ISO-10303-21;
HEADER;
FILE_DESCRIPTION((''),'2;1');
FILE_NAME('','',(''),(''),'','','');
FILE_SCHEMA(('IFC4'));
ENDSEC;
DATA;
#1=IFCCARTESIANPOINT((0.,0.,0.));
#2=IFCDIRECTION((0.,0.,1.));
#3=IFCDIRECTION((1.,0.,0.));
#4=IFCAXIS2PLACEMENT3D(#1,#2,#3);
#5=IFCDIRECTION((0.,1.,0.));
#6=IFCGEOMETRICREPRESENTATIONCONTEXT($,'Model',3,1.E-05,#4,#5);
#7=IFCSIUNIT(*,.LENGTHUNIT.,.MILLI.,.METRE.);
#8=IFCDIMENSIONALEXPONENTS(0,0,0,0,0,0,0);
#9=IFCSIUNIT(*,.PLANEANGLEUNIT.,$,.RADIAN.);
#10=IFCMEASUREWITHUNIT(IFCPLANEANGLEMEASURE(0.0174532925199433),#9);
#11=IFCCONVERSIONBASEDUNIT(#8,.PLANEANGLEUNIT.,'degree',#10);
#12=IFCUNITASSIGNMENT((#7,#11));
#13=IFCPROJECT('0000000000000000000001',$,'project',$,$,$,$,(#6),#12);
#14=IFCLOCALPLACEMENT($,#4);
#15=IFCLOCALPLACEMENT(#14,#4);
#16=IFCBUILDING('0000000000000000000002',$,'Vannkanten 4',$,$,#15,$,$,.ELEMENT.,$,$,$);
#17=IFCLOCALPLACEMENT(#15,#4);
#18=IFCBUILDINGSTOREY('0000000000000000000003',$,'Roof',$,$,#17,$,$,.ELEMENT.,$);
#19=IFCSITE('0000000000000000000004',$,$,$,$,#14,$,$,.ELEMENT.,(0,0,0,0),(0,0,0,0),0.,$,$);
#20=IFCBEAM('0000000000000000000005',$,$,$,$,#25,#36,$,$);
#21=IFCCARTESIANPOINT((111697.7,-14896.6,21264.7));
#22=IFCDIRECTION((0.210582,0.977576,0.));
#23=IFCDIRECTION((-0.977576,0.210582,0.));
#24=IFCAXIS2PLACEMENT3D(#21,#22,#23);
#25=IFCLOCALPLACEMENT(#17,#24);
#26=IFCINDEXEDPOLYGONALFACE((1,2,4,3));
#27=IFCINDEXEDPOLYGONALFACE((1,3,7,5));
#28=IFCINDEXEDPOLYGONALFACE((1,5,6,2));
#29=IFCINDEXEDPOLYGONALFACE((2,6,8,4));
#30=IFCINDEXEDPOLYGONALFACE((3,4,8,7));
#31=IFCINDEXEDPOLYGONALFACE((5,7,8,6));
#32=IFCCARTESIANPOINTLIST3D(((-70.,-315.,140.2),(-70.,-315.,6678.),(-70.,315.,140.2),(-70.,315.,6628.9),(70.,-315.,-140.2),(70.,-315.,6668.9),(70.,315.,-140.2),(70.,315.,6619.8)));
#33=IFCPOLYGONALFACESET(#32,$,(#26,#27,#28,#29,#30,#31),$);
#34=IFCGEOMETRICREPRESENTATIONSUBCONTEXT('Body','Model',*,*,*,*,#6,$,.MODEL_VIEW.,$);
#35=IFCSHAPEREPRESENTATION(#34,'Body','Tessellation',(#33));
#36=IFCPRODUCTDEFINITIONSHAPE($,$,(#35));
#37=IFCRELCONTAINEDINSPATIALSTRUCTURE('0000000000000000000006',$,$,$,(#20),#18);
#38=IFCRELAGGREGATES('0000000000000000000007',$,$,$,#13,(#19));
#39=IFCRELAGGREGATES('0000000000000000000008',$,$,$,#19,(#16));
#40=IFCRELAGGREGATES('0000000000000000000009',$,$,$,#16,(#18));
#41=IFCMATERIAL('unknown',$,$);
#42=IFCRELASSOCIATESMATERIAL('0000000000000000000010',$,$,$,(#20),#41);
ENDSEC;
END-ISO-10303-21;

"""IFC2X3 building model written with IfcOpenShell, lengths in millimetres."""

from ifc_helpers import new_model, entity, si_unit, converted_unit, direction, frame, origin_with_axes, place, context, subcontext, project, spatial, polyline, segment, composite_curve, outline, extrude, clip, halfspace, material, element, save


model = new_model("IFC2X3")

# Units and contexts
model_context = context("Model", 3, precision=1e-05, world=origin_with_axes(), true_north=direction((0.0, 1.0, 0.0)))
body_context = subcontext(model_context, "Body", "Model", "MODEL_VIEW")
ifc_project = project(units=[si_unit("LENGTHUNIT", "METRE", prefix="MILLI"), converted_unit("PLANEANGLEUNIT", "degree", entity("IfcPlaneAngleMeasure", 0.0174532925199433), si_unit("PLANEANGLEUNIT", "RADIAN"), dimensions=[0, 0, 0, 0, 0, 0, 0])], contexts=[model_context])

# Site, building, storey
site_placement = place(None, origin_with_axes())
site = spatial("IfcSite", under=ifc_project, at=site_placement, CompositionType="ELEMENT", RefLatitude=(0, 0, 0, 0), RefLongitude=(0, 0, 0, 0), RefElevation=0.0)
building_placement = place(site_placement, origin_with_axes())
building = spatial("IfcBuilding", under=site, at=building_placement, Name="Vannkanten 4", CompositionType="ELEMENT")
storey_placement = place(building_placement, origin_with_axes())
storey = spatial("IfcBuildingStorey", under=building, at=storey_placement, Name="Roof", CompositionType="ELEMENT")

# Shared definitions
ifc_material = material(Name="unknown")

# Beam
beam_1_placement = place(storey_placement, frame((111697.7, -14896.6, 21264.7), z_axis=(0.210582, 0.977576, 0.0), x_axis=(-0.977576, 0.210582, 0.0)))
element("IfcBeam", 1, at=beam_1_placement, inside=storey, material=ifc_material, context=body_context, shape_type="Clipping", body=[
    clip(clip(extrude(outline(composite_curve([segment(polyline([(-70.0, 315.0), (-70.0, -315.0), (70.0, -315.0), (70.0, 315.0), (-70.0, 315.0)]), True, "CONTINUOUS")], self_intersect=False)), frame((0.0, 0.0, -3549.3), z_axis=(0.0, 0.0, 1.0), x_axis=(1.0, 0.0, 0.0)), (0.0, 0.0, 1.0), 13636.4), halfspace(frame((-70.0, 315.0, 140.2), z_axis=(0.894664, 0.0, 0.446741), x_axis=(0.446741, 0.0, -0.894664)), True)), halfspace(frame((70.0, 315.0, 6619.8), z_axis=(-0.064556, -0.077476, -0.994902), x_axis=(0.0, -0.996982, 0.077638)), True)),
])

save(model, "model.ifc")
